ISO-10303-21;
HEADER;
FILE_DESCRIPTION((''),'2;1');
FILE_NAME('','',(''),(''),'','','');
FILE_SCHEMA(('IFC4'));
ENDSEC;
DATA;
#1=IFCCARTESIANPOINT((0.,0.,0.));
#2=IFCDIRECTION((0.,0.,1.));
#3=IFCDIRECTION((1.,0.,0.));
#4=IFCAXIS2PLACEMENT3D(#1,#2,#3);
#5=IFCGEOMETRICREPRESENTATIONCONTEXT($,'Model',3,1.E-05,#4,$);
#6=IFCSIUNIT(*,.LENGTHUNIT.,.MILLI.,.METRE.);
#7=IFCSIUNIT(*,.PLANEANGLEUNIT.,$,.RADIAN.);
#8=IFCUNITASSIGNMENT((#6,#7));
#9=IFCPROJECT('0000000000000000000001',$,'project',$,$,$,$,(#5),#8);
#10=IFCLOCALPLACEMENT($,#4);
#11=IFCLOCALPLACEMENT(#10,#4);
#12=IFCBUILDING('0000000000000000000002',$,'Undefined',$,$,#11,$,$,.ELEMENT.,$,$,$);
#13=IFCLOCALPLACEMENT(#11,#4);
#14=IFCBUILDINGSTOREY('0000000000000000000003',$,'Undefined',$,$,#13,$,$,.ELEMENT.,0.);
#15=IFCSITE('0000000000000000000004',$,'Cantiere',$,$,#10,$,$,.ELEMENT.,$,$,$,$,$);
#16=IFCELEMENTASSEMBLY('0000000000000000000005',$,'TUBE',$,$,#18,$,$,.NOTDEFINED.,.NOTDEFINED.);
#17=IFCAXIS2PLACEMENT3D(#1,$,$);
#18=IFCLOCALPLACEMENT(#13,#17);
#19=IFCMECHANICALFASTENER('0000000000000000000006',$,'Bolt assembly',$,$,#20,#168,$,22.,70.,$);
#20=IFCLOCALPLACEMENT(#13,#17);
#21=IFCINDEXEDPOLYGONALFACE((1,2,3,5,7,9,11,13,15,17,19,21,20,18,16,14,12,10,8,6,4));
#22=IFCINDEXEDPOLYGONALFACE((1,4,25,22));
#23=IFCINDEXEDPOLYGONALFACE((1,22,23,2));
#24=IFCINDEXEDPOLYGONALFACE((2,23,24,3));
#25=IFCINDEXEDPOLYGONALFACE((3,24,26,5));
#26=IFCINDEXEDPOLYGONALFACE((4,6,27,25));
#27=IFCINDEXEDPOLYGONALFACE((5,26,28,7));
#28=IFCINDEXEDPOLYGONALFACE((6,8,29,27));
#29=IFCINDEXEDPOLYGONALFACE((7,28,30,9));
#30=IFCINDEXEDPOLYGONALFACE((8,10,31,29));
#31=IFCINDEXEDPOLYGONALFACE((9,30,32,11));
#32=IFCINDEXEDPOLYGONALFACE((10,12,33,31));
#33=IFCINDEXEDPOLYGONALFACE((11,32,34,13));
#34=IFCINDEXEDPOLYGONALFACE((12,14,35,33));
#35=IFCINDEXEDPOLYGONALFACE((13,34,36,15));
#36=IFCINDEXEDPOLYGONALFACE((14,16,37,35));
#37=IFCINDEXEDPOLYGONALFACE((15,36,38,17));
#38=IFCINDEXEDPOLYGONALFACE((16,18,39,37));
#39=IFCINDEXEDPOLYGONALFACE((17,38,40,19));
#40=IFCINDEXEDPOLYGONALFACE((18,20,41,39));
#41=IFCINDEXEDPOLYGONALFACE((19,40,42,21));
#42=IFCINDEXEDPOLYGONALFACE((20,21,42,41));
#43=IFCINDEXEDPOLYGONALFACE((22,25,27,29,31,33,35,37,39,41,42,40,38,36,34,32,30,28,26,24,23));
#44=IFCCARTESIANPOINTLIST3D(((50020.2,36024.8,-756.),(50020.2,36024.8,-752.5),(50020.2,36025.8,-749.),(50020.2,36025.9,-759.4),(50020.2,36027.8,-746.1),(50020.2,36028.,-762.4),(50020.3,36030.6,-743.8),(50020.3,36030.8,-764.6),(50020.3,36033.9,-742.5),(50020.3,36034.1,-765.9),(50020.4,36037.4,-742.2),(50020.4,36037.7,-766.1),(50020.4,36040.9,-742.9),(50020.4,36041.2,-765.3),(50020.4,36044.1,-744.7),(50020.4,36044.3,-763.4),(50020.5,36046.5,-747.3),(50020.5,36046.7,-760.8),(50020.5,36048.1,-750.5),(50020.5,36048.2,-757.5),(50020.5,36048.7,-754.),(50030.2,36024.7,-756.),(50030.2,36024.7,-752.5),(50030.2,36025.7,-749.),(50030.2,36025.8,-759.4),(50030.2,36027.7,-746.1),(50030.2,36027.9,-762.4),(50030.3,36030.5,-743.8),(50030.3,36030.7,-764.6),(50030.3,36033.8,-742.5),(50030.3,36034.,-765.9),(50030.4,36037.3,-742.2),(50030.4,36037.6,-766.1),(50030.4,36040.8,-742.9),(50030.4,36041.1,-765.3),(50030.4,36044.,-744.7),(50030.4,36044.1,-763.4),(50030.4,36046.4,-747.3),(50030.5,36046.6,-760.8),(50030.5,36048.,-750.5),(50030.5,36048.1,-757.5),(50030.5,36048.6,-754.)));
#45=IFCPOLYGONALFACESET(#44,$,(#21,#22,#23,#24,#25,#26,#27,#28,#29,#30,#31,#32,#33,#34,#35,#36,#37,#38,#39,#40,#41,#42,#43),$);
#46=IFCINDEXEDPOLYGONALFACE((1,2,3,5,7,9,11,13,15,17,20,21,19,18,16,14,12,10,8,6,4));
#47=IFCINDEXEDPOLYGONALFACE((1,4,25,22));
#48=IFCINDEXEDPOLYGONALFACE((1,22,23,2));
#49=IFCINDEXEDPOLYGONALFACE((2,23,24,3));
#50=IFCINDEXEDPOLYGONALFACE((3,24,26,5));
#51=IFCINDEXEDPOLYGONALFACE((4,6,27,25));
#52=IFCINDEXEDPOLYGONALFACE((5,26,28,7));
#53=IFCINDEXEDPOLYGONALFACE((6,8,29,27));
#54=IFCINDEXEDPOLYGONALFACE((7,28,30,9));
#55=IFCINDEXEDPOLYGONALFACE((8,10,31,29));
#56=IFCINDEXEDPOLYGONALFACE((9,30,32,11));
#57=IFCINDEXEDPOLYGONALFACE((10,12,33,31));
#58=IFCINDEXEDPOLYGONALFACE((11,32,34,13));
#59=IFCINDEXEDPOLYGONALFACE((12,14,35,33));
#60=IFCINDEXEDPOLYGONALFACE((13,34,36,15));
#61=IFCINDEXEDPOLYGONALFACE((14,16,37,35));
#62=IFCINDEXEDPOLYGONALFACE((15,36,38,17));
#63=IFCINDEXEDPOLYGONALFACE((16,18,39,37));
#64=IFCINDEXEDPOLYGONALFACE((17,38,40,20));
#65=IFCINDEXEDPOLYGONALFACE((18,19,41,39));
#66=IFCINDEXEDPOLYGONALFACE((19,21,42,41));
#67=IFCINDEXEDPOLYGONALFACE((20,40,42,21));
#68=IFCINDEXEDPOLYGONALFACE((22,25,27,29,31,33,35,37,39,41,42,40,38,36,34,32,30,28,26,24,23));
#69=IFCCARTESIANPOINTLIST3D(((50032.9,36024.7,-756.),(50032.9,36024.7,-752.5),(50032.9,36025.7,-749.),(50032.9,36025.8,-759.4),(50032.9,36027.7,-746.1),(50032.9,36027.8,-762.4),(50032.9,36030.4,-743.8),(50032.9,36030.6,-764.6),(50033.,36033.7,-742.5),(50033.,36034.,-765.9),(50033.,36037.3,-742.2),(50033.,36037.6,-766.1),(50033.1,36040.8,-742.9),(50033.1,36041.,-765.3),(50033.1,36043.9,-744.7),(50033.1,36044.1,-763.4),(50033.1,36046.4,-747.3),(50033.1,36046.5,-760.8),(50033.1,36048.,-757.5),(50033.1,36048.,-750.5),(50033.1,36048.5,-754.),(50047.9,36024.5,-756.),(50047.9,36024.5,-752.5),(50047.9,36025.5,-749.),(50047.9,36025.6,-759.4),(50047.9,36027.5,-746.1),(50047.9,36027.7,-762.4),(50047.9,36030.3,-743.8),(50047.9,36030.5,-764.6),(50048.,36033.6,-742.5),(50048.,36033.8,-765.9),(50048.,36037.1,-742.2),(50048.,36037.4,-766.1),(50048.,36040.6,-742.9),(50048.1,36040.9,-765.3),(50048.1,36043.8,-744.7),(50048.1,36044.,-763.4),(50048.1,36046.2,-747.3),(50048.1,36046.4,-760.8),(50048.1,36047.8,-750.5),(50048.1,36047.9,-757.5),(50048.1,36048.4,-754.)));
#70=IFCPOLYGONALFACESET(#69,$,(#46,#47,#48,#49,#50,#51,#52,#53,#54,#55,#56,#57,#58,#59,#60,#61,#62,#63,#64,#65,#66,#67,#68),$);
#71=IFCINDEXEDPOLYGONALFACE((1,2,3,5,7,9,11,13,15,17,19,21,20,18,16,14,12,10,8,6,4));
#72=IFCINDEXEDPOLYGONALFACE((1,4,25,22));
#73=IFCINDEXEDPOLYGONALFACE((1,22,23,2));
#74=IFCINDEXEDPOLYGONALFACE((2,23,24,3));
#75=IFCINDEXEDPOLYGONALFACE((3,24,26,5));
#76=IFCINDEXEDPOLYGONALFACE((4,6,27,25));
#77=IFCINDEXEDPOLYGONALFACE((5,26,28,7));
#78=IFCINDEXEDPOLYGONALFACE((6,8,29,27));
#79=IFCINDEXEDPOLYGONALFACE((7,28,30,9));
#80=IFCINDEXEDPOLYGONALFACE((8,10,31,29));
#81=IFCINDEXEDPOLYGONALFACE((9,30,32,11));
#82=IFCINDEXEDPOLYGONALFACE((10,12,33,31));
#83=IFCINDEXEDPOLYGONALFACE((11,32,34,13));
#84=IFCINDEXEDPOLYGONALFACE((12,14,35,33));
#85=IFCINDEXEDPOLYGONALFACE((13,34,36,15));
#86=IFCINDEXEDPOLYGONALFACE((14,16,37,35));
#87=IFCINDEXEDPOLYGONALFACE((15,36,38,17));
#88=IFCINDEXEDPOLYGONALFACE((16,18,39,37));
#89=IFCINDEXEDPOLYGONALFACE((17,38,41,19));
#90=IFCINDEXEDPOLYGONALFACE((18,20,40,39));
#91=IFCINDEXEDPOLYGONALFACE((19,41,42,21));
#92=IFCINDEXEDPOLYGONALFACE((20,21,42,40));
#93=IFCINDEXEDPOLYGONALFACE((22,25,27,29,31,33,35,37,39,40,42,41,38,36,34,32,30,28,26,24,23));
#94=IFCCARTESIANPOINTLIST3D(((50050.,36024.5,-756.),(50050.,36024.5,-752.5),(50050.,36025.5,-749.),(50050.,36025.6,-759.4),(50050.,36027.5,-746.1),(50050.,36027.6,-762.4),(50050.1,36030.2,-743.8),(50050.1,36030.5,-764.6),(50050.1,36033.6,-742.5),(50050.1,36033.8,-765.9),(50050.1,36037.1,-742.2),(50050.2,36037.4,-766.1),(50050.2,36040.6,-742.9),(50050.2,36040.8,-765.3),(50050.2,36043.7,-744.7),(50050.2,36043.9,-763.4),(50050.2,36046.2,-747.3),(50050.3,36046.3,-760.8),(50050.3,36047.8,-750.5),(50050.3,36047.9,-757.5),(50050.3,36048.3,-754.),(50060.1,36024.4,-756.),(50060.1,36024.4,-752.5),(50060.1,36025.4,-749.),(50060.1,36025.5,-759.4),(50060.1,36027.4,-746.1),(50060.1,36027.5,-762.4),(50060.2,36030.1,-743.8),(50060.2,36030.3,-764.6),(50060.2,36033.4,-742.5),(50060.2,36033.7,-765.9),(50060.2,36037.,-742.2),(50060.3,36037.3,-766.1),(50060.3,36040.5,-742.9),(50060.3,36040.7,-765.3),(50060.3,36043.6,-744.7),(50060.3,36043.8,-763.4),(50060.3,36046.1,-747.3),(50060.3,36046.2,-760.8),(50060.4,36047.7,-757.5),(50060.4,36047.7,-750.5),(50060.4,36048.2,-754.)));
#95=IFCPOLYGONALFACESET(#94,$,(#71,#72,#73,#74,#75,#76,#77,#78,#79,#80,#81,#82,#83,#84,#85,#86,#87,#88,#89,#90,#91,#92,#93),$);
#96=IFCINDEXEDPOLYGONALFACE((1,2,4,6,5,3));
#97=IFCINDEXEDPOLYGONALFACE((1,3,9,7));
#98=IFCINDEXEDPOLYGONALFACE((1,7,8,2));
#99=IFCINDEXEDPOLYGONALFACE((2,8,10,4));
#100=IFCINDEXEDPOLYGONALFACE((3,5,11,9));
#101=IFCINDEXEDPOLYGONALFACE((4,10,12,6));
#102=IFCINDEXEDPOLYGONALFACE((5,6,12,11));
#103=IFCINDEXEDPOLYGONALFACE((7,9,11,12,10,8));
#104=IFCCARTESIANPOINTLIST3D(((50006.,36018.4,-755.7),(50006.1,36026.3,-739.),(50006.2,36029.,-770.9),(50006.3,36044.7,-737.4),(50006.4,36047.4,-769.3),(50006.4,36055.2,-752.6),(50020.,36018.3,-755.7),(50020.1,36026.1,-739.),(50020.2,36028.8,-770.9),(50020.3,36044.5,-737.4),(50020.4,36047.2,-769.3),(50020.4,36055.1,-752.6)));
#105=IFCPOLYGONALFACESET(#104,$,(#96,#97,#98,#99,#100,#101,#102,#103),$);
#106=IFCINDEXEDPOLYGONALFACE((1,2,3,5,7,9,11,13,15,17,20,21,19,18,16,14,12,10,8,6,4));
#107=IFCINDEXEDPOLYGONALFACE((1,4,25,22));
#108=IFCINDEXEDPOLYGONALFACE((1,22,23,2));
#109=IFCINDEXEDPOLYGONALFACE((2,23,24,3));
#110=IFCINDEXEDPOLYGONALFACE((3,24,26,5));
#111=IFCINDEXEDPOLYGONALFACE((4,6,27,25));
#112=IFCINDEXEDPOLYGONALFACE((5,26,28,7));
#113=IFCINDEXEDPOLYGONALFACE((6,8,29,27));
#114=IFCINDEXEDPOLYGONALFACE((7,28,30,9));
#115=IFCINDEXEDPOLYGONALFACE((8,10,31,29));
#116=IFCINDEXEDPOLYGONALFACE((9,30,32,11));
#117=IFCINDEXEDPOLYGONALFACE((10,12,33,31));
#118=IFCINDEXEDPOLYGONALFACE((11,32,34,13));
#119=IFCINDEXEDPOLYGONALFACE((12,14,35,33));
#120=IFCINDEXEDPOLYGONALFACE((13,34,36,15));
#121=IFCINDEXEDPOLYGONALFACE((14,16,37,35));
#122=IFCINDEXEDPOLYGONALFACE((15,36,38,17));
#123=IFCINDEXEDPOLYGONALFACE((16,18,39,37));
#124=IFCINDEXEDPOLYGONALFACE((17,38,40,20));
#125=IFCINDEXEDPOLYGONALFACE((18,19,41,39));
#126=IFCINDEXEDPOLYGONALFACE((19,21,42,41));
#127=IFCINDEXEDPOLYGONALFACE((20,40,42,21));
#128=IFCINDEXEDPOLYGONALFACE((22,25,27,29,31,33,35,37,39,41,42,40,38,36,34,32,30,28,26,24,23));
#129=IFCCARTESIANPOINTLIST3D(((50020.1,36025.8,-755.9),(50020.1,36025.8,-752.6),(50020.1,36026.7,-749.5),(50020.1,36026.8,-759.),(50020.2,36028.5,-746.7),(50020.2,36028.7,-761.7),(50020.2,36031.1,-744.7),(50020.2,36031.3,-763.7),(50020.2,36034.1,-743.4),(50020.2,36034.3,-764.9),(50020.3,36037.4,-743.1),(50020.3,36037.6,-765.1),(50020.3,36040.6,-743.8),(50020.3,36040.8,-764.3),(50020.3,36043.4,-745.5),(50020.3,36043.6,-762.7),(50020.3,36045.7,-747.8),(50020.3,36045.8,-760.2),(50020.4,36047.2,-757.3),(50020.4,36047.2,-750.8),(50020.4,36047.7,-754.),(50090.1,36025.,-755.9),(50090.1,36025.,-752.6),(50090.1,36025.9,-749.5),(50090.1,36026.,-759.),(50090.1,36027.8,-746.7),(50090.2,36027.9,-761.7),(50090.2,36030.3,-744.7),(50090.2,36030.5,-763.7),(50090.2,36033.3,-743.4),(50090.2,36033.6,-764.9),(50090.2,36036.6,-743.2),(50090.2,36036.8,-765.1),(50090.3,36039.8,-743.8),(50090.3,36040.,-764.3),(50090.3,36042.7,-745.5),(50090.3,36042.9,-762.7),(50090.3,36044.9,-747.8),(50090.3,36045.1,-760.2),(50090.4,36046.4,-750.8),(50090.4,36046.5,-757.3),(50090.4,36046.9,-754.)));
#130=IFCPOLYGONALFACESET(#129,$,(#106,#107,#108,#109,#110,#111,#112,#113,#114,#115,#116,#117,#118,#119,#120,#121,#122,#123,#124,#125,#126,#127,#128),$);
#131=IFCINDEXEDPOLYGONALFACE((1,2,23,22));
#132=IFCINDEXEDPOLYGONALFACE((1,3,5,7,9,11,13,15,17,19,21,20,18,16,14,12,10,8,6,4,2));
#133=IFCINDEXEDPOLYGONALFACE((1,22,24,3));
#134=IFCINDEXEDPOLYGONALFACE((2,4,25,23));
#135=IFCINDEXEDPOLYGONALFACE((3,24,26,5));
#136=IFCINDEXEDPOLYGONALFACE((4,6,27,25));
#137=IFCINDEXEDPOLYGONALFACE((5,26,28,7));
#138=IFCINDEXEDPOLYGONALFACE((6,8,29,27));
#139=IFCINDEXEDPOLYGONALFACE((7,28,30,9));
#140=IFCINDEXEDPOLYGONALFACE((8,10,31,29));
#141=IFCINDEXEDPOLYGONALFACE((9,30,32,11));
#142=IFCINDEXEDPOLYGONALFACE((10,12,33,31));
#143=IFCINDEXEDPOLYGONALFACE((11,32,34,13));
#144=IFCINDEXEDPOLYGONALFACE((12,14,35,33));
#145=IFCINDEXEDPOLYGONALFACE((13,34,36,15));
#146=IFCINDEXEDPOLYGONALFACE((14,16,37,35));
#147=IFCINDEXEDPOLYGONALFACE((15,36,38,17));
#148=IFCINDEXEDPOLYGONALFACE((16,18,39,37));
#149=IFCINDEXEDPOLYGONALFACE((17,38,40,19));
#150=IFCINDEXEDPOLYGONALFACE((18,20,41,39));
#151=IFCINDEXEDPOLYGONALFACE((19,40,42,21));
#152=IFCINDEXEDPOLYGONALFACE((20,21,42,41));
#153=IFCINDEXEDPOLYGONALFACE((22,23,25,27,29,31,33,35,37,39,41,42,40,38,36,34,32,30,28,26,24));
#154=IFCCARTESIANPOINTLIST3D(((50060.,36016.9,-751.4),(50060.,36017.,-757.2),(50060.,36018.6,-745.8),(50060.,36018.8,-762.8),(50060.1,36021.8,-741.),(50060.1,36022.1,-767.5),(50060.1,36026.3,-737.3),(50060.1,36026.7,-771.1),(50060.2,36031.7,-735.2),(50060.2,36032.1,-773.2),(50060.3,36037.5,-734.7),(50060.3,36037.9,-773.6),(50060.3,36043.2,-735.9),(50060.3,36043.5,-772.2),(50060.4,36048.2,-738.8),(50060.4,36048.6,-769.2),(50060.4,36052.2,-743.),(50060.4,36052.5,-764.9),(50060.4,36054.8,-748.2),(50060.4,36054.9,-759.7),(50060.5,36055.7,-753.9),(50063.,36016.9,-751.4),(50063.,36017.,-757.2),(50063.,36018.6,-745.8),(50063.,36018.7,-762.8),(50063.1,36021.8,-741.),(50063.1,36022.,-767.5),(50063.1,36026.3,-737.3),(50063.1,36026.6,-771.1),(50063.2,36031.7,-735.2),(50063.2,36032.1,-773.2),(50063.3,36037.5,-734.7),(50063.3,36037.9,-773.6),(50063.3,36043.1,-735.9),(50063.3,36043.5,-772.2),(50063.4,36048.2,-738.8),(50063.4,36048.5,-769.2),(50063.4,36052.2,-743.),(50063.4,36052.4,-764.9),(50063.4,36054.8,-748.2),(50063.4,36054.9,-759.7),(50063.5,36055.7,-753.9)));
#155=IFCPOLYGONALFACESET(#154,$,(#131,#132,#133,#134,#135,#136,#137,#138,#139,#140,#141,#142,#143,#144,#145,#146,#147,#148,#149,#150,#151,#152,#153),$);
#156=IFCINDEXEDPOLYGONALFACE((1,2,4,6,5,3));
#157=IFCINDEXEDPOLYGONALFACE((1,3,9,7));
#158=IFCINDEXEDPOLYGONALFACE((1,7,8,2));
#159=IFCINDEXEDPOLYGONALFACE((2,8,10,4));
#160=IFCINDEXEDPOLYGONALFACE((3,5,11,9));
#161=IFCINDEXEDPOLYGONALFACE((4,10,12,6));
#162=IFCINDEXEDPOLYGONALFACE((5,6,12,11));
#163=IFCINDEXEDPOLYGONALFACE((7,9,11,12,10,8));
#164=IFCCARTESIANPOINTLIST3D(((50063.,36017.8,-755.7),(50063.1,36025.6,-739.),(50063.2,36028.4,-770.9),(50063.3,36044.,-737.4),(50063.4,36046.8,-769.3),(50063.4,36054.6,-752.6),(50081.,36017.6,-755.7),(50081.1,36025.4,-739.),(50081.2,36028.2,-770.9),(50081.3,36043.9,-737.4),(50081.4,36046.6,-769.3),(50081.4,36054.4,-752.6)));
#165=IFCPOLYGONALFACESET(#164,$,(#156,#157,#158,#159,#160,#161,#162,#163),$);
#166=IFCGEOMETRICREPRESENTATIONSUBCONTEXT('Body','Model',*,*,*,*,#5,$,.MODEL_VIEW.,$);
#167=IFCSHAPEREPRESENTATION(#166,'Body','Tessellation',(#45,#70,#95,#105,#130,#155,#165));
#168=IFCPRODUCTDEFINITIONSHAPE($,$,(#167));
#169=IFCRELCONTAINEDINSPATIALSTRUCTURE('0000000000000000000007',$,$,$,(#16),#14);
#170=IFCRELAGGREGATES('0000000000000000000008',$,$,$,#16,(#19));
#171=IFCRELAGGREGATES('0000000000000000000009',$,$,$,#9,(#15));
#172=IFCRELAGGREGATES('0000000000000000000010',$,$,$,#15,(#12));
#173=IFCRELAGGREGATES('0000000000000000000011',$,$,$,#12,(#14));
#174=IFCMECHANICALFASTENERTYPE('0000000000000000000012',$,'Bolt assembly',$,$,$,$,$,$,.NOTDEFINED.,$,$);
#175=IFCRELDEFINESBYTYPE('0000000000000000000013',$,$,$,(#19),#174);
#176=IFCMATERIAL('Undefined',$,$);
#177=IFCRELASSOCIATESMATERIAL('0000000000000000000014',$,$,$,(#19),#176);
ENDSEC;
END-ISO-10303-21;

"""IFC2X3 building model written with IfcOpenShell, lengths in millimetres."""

from ifc_helpers import new_model, si_unit, frame, origin_with_axes, origin_2d_with_axis, place, context, subcontext, project, spatial, polyline, circle, outline, extrude, source, transform, mapped, material, type_object, element, aggregate, save


model = new_model("IFC2X3")

# Units and contexts
model_context = context("Model", 3, precision=1e-05, world=origin_with_axes())
body_context = subcontext(model_context, "Body", "Model", "MODEL_VIEW")
ifc_project = project(units=[si_unit("LENGTHUNIT", "METRE", prefix="MILLI"), si_unit("PLANEANGLEUNIT", "RADIAN")], contexts=[model_context])

# Site, building, storey
site_placement = place(None, origin_with_axes())
site = spatial("IfcSite", under=ifc_project, at=site_placement, Name="Cantiere", CompositionType="ELEMENT")
building_placement = place(site_placement, origin_with_axes())
building = spatial("IfcBuilding", under=site, at=building_placement, Name="Undefined", CompositionType="ELEMENT")
storey_placement = place(building_placement, origin_with_axes())
storey = spatial("IfcBuildingStorey", under=building, at=storey_placement, Name="Undefined", CompositionType="ELEMENT", Elevation=0.0)

# Element assembly
assembly_1_placement = place(storey_placement, origin_with_axes())
assembly_1 = element("IfcElementAssembly", 1, at=assembly_1_placement, inside=storey, Name="TUBE", AssemblyPlace="NOTDEFINED", PredefinedType="NOTDEFINED")

# Mechanical fastener
ifc_material_1 = material(Name="Undefined")
mechanical_fastener_type = type_object("IfcMechanicalFastenerType", Name="Bolt assembly")
shared_shape = source(origin_with_axes(), body_context, "Body", "SweptSolid", [
    extrude(circle(Radius=12.0, at=origin_2d_with_axis()), frame((0.0, -39.9, 0.0), z_axis=(0.0, 1.0, 0.0), x_axis=(1.0, 0.0, 0.0)), (0.0, 0.0, 1.0), 10.0),
    extrude(circle(Radius=12.0, at=origin_2d_with_axis()), frame((0.0, -27.2, 0.0), z_axis=(0.0, 1.0, 0.0), x_axis=(1.0, 0.0, 0.0)), (0.0, 0.0, 1.0), 15.0),
    extrude(circle(Radius=12.0, at=origin_2d_with_axis()), frame((0.0, -10.1, 0.0), z_axis=(0.0, 1.0, 0.0), x_axis=(1.0, 0.0, 0.0)), (0.0, 0.0, 1.0), 10.1),
    extrude(outline(polyline([(16.0, -9.2), (16.0, 9.2), (0.0, 18.5), (-16.0, 9.2), (-16.0, -9.2), (0.0, -18.5), (16.0, -9.2)])), frame((0.0, -54.0, 0.0), z_axis=(0.0, 1.0, 0.0), x_axis=(1.0, 0.0, 0.0)), (0.0, 0.0, 1.0), 14.0),
    extrude(circle(Radius=11.0, at=origin_2d_with_axis()), frame((0.0, -40.0, 0.0), z_axis=(0.0, 1.0, 0.0), x_axis=(1.0, 0.0, 0.0)), (0.0, 0.0, 1.0), 70.0),
    extrude(circle(Radius=19.5, at=origin_2d_with_axis()), frame((0.0, 0.0, 0.0), z_axis=(0.0, 1.0, 0.0), x_axis=(1.0, 0.0, 0.0)), (0.0, 0.0, 1.0), 3.0),
    extrude(outline(polyline([(16.0, -9.2), (16.0, 9.2), (0.0, 18.5), (-16.0, 9.2), (-16.0, -9.2), (0.0, -18.5), (16.0, -9.2)])), frame((0.0, 3.0, 0.0), z_axis=(0.0, 1.0, 0.0), x_axis=(1.0, 0.0, 0.0)), (0.0, 0.0, 1.0), 18.0),
])
mechanical_fastener_1_placement = place(assembly_1_placement, frame((50060.2, 36036.2, -754.1), z_axis=(0.004676, 0.424511, 0.905411), x_axis=(-0.009958, -0.905356, 0.424536)))
mechanical_fastener_1 = element("IfcMechanicalFastener", 2, at=mechanical_fastener_1_placement, type_object=mechanical_fastener_type, material=ifc_material_1, Name="Bolt assembly", NominalDiameter=22.0, NominalLength=70.0, context=body_context, shape_type="MappedRepresentation", body=[
    mapped(shared_shape, transform((0.0, 0.0, 0.0))),
])
aggregate(assembly_1, [mechanical_fastener_1])

save(model, "model.ifc")
